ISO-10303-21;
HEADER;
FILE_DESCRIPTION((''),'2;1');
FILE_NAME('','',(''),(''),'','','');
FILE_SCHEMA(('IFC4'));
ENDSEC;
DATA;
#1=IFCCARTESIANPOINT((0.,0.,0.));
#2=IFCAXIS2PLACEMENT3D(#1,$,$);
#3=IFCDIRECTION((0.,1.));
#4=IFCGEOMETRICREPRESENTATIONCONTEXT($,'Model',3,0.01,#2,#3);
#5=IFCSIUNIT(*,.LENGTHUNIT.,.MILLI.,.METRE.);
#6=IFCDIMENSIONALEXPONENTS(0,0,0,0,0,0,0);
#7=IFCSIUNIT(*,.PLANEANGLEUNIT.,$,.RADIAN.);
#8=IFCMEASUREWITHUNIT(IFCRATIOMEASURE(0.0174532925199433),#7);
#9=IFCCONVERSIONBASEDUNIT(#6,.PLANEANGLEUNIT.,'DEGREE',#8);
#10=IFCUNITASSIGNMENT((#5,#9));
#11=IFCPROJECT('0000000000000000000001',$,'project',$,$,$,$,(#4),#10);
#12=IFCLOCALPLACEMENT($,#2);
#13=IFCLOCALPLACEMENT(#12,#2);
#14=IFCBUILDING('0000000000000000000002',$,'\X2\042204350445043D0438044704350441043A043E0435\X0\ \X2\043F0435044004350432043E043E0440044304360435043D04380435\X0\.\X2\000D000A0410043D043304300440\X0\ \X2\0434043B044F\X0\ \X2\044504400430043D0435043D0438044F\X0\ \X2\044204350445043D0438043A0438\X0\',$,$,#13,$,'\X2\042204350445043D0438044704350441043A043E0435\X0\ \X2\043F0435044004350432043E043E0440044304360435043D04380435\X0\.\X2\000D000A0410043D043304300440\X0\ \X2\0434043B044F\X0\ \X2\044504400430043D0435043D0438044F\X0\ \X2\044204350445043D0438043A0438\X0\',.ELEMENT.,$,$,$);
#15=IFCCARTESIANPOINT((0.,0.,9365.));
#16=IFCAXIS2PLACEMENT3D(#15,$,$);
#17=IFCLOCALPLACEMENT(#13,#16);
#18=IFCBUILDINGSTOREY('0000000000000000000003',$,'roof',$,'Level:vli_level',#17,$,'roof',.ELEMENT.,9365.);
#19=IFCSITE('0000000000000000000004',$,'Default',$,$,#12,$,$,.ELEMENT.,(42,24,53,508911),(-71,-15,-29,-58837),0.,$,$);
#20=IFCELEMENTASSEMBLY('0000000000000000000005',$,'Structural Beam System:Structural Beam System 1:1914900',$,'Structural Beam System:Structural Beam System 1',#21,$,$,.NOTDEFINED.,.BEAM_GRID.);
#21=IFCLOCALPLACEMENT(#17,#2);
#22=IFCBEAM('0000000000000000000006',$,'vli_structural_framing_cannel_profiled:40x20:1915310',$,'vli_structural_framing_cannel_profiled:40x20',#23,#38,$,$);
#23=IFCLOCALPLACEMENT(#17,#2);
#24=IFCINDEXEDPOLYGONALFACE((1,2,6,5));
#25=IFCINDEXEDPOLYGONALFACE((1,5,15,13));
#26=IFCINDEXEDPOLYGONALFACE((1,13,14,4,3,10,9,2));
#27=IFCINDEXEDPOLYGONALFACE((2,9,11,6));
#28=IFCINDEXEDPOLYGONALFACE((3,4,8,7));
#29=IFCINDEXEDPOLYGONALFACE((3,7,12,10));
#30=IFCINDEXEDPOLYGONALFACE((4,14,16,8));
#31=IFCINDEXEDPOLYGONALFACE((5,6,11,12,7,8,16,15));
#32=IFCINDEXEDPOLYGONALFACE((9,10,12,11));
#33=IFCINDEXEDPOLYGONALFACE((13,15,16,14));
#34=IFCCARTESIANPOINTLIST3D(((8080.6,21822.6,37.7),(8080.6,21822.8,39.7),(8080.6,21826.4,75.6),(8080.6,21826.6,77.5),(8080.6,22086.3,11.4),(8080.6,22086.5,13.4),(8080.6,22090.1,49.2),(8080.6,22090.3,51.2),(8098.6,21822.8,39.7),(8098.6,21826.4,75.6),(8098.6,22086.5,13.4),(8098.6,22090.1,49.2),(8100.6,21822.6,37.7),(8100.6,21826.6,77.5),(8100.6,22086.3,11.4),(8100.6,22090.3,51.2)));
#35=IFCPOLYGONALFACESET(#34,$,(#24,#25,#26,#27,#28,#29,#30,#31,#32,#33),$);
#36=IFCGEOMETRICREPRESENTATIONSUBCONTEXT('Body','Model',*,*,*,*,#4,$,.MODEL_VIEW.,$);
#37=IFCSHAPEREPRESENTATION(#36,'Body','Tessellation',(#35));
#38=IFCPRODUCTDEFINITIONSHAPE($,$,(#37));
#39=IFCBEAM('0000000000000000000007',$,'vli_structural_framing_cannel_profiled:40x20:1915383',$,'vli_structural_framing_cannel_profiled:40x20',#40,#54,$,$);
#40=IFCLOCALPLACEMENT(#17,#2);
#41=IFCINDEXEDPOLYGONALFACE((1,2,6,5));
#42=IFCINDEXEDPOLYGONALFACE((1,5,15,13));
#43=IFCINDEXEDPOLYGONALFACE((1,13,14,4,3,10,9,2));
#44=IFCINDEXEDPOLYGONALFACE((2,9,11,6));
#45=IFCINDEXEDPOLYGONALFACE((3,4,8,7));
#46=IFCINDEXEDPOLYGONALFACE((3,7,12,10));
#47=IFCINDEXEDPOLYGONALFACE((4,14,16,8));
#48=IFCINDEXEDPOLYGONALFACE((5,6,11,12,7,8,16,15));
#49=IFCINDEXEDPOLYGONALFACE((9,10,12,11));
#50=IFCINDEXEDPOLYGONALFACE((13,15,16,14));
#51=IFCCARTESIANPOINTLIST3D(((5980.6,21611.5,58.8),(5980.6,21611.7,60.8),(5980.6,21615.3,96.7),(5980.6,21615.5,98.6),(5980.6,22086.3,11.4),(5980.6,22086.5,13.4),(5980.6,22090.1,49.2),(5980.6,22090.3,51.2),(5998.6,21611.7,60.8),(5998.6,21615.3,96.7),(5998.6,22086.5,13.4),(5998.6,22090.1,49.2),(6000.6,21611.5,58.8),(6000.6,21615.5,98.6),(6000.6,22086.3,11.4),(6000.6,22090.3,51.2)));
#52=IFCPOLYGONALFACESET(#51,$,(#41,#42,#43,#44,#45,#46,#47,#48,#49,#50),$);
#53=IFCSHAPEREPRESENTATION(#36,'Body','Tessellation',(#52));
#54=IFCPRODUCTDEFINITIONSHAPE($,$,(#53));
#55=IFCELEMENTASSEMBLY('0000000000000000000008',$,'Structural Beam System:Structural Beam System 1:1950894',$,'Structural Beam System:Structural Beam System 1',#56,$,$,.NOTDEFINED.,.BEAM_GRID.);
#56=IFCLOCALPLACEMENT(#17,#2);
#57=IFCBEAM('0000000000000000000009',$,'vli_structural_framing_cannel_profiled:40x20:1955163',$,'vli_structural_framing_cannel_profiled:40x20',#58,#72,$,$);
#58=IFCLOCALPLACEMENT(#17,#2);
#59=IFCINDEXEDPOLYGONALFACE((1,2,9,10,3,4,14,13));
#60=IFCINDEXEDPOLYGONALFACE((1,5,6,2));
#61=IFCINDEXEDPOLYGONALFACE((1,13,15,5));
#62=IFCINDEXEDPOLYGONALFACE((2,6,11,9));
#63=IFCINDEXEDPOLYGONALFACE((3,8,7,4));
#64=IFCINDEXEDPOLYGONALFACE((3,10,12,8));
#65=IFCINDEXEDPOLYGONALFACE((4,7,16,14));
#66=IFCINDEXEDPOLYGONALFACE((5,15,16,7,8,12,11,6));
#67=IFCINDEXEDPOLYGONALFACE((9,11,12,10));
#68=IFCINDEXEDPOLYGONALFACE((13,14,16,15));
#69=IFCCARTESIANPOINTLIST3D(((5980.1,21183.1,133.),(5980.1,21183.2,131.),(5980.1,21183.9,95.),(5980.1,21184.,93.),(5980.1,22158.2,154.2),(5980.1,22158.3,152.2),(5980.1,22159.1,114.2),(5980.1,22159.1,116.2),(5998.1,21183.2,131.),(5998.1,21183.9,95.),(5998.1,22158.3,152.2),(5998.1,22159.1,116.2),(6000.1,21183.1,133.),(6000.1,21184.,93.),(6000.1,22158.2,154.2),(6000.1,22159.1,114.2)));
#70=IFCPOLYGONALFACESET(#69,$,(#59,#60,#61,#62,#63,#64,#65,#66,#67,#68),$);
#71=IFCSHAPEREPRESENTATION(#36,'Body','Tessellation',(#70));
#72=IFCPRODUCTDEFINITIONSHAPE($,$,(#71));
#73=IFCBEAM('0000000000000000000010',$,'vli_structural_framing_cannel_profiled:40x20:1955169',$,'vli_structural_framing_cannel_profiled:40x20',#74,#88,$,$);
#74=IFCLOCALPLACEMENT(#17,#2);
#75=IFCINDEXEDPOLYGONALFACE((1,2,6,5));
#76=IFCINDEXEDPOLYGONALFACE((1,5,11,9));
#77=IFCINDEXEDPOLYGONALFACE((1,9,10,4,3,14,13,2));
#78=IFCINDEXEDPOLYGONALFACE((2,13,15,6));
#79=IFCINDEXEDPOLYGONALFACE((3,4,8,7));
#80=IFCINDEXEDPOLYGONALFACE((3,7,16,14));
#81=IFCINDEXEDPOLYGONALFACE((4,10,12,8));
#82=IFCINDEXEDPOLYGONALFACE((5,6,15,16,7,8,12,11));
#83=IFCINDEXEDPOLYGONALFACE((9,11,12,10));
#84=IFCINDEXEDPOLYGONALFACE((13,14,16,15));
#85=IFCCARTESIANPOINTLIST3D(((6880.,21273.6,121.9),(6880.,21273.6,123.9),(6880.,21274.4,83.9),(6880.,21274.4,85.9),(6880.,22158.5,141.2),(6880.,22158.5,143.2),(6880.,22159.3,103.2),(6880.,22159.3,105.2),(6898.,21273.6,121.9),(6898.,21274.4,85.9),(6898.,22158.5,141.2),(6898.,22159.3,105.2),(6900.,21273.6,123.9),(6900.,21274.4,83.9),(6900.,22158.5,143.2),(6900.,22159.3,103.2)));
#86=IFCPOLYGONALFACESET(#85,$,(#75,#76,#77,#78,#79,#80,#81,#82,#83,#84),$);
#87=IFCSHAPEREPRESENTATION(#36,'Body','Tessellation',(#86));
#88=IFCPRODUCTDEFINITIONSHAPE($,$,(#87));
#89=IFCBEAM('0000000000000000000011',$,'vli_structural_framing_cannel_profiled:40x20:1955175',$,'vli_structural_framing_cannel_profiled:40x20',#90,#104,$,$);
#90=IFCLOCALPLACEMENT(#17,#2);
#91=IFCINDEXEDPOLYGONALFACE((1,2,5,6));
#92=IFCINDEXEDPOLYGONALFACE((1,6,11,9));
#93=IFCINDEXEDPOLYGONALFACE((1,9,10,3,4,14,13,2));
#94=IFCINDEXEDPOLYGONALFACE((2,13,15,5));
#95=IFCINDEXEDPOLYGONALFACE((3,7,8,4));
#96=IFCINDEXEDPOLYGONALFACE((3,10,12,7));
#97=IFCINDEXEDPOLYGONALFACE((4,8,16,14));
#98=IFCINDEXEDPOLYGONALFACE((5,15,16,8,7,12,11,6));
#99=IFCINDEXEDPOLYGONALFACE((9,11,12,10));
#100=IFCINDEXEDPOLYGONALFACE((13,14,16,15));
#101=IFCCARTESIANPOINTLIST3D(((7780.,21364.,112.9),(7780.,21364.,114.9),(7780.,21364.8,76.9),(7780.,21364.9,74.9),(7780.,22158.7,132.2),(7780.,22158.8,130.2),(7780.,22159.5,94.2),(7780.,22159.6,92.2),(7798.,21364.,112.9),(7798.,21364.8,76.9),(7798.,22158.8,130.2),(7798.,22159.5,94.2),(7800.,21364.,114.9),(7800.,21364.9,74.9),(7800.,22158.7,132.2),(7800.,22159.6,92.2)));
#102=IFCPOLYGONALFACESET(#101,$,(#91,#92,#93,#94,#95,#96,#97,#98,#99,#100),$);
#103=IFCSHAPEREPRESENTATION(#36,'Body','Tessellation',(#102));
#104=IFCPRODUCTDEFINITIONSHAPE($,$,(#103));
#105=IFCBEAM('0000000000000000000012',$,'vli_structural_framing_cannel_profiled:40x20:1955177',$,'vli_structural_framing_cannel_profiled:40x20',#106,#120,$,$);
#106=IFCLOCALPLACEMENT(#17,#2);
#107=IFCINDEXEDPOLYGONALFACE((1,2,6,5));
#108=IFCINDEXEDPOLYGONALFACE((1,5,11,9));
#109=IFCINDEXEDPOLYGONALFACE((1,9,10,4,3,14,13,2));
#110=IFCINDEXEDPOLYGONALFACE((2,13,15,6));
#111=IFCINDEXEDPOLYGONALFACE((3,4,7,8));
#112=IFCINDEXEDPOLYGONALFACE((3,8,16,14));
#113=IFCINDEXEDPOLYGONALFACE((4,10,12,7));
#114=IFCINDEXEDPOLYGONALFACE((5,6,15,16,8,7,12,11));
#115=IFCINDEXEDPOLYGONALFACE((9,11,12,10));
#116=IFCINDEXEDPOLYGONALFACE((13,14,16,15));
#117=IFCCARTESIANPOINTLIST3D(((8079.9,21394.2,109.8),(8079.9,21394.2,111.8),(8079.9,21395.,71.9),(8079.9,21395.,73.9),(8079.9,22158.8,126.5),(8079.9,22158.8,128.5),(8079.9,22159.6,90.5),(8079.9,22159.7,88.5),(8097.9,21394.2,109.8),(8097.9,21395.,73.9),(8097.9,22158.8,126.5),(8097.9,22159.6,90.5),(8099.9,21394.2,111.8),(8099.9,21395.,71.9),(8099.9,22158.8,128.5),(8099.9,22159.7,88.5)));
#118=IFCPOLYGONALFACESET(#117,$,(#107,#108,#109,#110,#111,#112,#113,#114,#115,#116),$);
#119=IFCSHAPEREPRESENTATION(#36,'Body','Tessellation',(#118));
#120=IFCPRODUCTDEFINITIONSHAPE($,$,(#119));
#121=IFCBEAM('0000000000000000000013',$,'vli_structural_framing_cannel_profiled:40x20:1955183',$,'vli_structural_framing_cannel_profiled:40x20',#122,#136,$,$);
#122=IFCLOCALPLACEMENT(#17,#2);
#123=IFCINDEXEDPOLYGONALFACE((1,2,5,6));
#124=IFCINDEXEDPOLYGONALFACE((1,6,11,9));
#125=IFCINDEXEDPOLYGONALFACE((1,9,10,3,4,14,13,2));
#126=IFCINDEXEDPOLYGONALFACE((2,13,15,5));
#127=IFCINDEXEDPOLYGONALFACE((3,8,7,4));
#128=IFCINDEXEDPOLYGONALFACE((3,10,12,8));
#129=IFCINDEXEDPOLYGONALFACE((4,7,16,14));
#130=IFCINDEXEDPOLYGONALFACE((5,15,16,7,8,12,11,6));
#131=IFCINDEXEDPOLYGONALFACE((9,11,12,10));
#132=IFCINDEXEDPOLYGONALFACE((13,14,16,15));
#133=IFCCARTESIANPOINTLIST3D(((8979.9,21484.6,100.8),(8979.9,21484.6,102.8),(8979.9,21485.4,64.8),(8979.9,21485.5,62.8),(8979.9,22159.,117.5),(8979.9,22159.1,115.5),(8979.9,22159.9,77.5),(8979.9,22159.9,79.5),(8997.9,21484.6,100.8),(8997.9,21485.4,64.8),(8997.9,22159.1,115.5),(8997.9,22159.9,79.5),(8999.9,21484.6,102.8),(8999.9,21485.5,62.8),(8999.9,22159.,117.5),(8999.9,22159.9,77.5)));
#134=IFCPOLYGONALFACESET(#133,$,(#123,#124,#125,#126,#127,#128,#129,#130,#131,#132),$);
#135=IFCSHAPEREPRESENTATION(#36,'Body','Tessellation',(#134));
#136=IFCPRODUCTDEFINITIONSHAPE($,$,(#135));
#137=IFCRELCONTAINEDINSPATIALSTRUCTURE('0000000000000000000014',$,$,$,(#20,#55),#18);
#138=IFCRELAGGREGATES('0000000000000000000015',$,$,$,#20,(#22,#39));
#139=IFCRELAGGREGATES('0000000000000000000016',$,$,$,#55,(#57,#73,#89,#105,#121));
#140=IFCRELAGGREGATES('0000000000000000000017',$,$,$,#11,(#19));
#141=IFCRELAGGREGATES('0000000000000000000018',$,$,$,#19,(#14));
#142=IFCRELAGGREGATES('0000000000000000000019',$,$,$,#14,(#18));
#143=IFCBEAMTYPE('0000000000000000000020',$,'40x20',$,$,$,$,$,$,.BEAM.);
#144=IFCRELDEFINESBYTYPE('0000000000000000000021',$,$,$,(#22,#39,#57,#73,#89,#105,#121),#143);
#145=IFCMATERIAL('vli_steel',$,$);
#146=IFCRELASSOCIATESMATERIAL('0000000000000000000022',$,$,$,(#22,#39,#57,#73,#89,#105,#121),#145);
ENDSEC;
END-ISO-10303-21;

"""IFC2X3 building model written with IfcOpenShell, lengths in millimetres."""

from ifc_helpers import new_model, entity, si_unit, converted_unit, direction, frame, origin, place, context, subcontext, project, spatial, polyline, outline, extrude, material, type_object, element, aggregate, save


model = new_model("IFC2X3")

# Units and contexts
model_context = context("Model", 3, precision=0.01, world=origin(), true_north=direction((0.0, 1.0)))
body_context = subcontext(model_context, "Body", "Model", "MODEL_VIEW")
ifc_project = project(units=[si_unit("LENGTHUNIT", "METRE", prefix="MILLI"), converted_unit("PLANEANGLEUNIT", "DEGREE", entity("IfcRatioMeasure", 0.0174532925199433), si_unit("PLANEANGLEUNIT", "RADIAN"), dimensions=[0, 0, 0, 0, 0, 0, 0])], contexts=[model_context])

# Site, building, storey
site_placement = place(None, origin())
site = spatial("IfcSite", under=ifc_project, at=site_placement, Name="Default", CompositionType="ELEMENT", RefLatitude=(42, 24, 53, 508911), RefLongitude=(-71, -15, -29, -58837), RefElevation=0.0)
building_placement = place(site_placement, origin())
building = spatial("IfcBuilding", under=site, at=building_placement, Name="Техническое перевооружение.\r\nАнгар для хранения техники", LongName="Техническое перевооружение.\r\nАнгар для хранения техники", CompositionType="ELEMENT")
storey_placement = place(building_placement, frame((0.0, 0.0, 9365.0)))
storey = spatial("IfcBuildingStorey", under=building, at=storey_placement, Name="roof", ObjectType="Level:vli_level", LongName="roof", CompositionType="ELEMENT", Elevation=9365.0)

# Element assemblies, beams
assembly_1_placement = place(storey_placement, origin())
assembly_1 = element("IfcElementAssembly", 1, at=assembly_1_placement, inside=storey, Name="Structural Beam System:Structural Beam System 1:1914900", ObjectType="Structural Beam System:Structural Beam System 1", AssemblyPlace="NOTDEFINED", PredefinedType="BEAM_GRID")
ifc_material = material(Name="vli_steel")
beam_type = type_object("IfcBeamType", Name="40x20", PredefinedType="BEAM")
beam_1_placement = place(assembly_1_placement, frame((8100.0, 22090.8, 10.9), z_axis=(0.0, 0.099504, 0.995037), x_axis=(0.0, -0.995037, 0.099504)))
beam_1 = element("IfcBeam", 2, at=beam_1_placement, type_object=beam_type, material=ifc_material, Name="vli_structural_framing_cannel_profiled:40x20:1915310", ObjectType="vli_structural_framing_cannel_profiled:40x20", context=body_context, shape_type="SweptSolid", body=[
    extrude(outline(polyline([(-20.0, -9.5), (-18.0, -9.5), (-18.0, 8.5), (18.0, 8.5), (18.0, -9.5), (20.0, -9.5), (20.0, 10.5), (-20.0, 10.5), (-20.0, -9.5)])), frame((4.6, -9.9, 20.0), z_axis=(1.0, 0.0, 0.0), x_axis=(0.0, 0.0, -1.0)), (0.0, 0.0, 1.0), 265.0),
])
beam_2_placement = place(assembly_1_placement, frame((6000.0, 22090.8, 10.9), z_axis=(0.0, 0.099504, 0.995037), x_axis=(0.0, -0.995037, 0.099504)))
beam_2 = element("IfcBeam", 3, at=beam_2_placement, type_object=beam_type, material=ifc_material, Name="vli_structural_framing_cannel_profiled:40x20:1915383", ObjectType="vli_structural_framing_cannel_profiled:40x20", context=body_context, shape_type="SweptSolid", body=[
    extrude(outline(polyline([(-20.0, -9.5), (-18.0, -9.5), (-18.0, 8.5), (18.0, 8.5), (18.0, -9.5), (20.0, -9.5), (20.0, 10.5), (-20.0, 10.5), (-20.0, -9.5)])), frame((4.6, -9.9, 20.0), z_axis=(1.0, 0.0, 0.0), x_axis=(0.0, 0.0, -1.0)), (0.0, 0.0, 1.0), 477.1),
])
aggregate(assembly_1, [beam_1, beam_2])
assembly_2_placement = place(storey_placement, origin())
assembly_2 = element("IfcElementAssembly", 4, at=assembly_2_placement, inside=storey, Name="Structural Beam System:Structural Beam System 1:1950894", ObjectType="Structural Beam System:Structural Beam System 1", AssemblyPlace="NOTDEFINED", PredefinedType="BEAM_GRID")
beam_3_placement = place(assembly_2_placement, frame((5999.5, 22159.7, 154.2), z_axis=(0.0, -0.021793, 0.999763), x_axis=(0.0, -0.999763, -0.021793)))
beam_3 = element("IfcBeam", 5, at=beam_3_placement, type_object=beam_type, material=ifc_material, Name="vli_structural_framing_cannel_profiled:40x20:1955163", ObjectType="vli_structural_framing_cannel_profiled:40x20", context=body_context, shape_type="SweptSolid", body=[
    extrude(outline(polyline([(-20.0, -9.5), (-18.0, -9.5), (-18.0, 8.5), (18.0, 8.5), (18.0, -9.5), (20.0, -9.5), (20.0, 10.5), (-20.0, 10.5), (-20.0, -9.5)])), frame((1.5, -9.9, -20.0), z_axis=(1.0, 0.0, 0.0), x_axis=(0.0, 0.0, -1.0)), (0.0, 0.0, 1.0), 975.4),
])
beam_4_placement = place(assembly_2_placement, frame((6899.4, 22159.9, 143.2), z_axis=(0.0, -0.021793, 0.999763), x_axis=(0.0, -0.999763, -0.021793)))
beam_4 = element("IfcBeam", 6, at=beam_4_placement, type_object=beam_type, material=ifc_material, Name="vli_structural_framing_cannel_profiled:40x20:1955169", ObjectType="vli_structural_framing_cannel_profiled:40x20", context=body_context, shape_type="SweptSolid", body=[
    extrude(outline(polyline([(-20.0, -9.5), (-18.0, -9.5), (-18.0, 8.5), (18.0, 8.5), (18.0, -9.5), (20.0, -9.5), (20.0, 10.5), (-20.0, 10.5), (-20.0, -9.5)])), frame((1.5, -9.9, -20.0), z_axis=(1.0, 0.0, 0.0), x_axis=(0.0, 0.0, -1.0)), (0.0, 0.0, 1.0), 885.1),
])
beam_5_placement = place(assembly_2_placement, frame((7799.4, 22160.2, 132.2), z_axis=(0.0, -0.021793, 0.999763), x_axis=(0.0, -0.999763, -0.021793)))
beam_5 = element("IfcBeam", 7, at=beam_5_placement, type_object=beam_type, material=ifc_material, Name="vli_structural_framing_cannel_profiled:40x20:1955175", ObjectType="vli_structural_framing_cannel_profiled:40x20", context=body_context, shape_type="SweptSolid", body=[
    extrude(outline(polyline([(-20.0, -9.5), (-18.0, -9.5), (-18.0, 8.5), (18.0, 8.5), (18.0, -9.5), (20.0, -9.5), (20.0, 10.5), (-20.0, 10.5), (-20.0, -9.5)])), frame((1.5, -9.9, -20.0), z_axis=(1.0, 0.0, 0.0), x_axis=(0.0, 0.0, -1.0)), (0.0, 0.0, 1.0), 794.9),
])
beam_6_placement = place(assembly_2_placement, frame((8099.3, 22160.3, 128.5), z_axis=(0.0, -0.021793, 0.999763), x_axis=(0.0, -0.999763, -0.021793)))
beam_6 = element("IfcBeam", 8, at=beam_6_placement, type_object=beam_type, material=ifc_material, Name="vli_structural_framing_cannel_profiled:40x20:1955177", ObjectType="vli_structural_framing_cannel_profiled:40x20", context=body_context, shape_type="SweptSolid", body=[
    extrude(outline(polyline([(-20.0, -9.5), (-18.0, -9.5), (-18.0, 8.5), (18.0, 8.5), (18.0, -9.5), (20.0, -9.5), (20.0, 10.5), (-20.0, 10.5), (-20.0, -9.5)])), frame((1.5, -9.9, -20.0), z_axis=(1.0, 0.0, 0.0), x_axis=(0.0, 0.0, -1.0)), (0.0, 0.0, 1.0), 764.8),
])
beam_7_placement = place(assembly_2_placement, frame((8999.3, 22160.5, 117.5), z_axis=(0.0, -0.021793, 0.999763), x_axis=(0.0, -0.999763, -0.021793)))
beam_7 = element("IfcBeam", 9, at=beam_7_placement, type_object=beam_type, material=ifc_material, Name="vli_structural_framing_cannel_profiled:40x20:1955183", ObjectType="vli_structural_framing_cannel_profiled:40x20", context=body_context, shape_type="SweptSolid", body=[
    extrude(outline(polyline([(-20.0, -9.5), (-18.0, -9.5), (-18.0, 8.5), (18.0, 8.5), (18.0, -9.5), (20.0, -9.5), (20.0, 10.5), (-20.0, 10.5), (-20.0, -9.5)])), frame((1.5, -9.9, -20.0), z_axis=(1.0, 0.0, 0.0), x_axis=(0.0, 0.0, -1.0)), (0.0, 0.0, 1.0), 674.6),
])
aggregate(assembly_2, [beam_3, beam_4, beam_5, beam_6, beam_7])

save(model, "model.ifc")
